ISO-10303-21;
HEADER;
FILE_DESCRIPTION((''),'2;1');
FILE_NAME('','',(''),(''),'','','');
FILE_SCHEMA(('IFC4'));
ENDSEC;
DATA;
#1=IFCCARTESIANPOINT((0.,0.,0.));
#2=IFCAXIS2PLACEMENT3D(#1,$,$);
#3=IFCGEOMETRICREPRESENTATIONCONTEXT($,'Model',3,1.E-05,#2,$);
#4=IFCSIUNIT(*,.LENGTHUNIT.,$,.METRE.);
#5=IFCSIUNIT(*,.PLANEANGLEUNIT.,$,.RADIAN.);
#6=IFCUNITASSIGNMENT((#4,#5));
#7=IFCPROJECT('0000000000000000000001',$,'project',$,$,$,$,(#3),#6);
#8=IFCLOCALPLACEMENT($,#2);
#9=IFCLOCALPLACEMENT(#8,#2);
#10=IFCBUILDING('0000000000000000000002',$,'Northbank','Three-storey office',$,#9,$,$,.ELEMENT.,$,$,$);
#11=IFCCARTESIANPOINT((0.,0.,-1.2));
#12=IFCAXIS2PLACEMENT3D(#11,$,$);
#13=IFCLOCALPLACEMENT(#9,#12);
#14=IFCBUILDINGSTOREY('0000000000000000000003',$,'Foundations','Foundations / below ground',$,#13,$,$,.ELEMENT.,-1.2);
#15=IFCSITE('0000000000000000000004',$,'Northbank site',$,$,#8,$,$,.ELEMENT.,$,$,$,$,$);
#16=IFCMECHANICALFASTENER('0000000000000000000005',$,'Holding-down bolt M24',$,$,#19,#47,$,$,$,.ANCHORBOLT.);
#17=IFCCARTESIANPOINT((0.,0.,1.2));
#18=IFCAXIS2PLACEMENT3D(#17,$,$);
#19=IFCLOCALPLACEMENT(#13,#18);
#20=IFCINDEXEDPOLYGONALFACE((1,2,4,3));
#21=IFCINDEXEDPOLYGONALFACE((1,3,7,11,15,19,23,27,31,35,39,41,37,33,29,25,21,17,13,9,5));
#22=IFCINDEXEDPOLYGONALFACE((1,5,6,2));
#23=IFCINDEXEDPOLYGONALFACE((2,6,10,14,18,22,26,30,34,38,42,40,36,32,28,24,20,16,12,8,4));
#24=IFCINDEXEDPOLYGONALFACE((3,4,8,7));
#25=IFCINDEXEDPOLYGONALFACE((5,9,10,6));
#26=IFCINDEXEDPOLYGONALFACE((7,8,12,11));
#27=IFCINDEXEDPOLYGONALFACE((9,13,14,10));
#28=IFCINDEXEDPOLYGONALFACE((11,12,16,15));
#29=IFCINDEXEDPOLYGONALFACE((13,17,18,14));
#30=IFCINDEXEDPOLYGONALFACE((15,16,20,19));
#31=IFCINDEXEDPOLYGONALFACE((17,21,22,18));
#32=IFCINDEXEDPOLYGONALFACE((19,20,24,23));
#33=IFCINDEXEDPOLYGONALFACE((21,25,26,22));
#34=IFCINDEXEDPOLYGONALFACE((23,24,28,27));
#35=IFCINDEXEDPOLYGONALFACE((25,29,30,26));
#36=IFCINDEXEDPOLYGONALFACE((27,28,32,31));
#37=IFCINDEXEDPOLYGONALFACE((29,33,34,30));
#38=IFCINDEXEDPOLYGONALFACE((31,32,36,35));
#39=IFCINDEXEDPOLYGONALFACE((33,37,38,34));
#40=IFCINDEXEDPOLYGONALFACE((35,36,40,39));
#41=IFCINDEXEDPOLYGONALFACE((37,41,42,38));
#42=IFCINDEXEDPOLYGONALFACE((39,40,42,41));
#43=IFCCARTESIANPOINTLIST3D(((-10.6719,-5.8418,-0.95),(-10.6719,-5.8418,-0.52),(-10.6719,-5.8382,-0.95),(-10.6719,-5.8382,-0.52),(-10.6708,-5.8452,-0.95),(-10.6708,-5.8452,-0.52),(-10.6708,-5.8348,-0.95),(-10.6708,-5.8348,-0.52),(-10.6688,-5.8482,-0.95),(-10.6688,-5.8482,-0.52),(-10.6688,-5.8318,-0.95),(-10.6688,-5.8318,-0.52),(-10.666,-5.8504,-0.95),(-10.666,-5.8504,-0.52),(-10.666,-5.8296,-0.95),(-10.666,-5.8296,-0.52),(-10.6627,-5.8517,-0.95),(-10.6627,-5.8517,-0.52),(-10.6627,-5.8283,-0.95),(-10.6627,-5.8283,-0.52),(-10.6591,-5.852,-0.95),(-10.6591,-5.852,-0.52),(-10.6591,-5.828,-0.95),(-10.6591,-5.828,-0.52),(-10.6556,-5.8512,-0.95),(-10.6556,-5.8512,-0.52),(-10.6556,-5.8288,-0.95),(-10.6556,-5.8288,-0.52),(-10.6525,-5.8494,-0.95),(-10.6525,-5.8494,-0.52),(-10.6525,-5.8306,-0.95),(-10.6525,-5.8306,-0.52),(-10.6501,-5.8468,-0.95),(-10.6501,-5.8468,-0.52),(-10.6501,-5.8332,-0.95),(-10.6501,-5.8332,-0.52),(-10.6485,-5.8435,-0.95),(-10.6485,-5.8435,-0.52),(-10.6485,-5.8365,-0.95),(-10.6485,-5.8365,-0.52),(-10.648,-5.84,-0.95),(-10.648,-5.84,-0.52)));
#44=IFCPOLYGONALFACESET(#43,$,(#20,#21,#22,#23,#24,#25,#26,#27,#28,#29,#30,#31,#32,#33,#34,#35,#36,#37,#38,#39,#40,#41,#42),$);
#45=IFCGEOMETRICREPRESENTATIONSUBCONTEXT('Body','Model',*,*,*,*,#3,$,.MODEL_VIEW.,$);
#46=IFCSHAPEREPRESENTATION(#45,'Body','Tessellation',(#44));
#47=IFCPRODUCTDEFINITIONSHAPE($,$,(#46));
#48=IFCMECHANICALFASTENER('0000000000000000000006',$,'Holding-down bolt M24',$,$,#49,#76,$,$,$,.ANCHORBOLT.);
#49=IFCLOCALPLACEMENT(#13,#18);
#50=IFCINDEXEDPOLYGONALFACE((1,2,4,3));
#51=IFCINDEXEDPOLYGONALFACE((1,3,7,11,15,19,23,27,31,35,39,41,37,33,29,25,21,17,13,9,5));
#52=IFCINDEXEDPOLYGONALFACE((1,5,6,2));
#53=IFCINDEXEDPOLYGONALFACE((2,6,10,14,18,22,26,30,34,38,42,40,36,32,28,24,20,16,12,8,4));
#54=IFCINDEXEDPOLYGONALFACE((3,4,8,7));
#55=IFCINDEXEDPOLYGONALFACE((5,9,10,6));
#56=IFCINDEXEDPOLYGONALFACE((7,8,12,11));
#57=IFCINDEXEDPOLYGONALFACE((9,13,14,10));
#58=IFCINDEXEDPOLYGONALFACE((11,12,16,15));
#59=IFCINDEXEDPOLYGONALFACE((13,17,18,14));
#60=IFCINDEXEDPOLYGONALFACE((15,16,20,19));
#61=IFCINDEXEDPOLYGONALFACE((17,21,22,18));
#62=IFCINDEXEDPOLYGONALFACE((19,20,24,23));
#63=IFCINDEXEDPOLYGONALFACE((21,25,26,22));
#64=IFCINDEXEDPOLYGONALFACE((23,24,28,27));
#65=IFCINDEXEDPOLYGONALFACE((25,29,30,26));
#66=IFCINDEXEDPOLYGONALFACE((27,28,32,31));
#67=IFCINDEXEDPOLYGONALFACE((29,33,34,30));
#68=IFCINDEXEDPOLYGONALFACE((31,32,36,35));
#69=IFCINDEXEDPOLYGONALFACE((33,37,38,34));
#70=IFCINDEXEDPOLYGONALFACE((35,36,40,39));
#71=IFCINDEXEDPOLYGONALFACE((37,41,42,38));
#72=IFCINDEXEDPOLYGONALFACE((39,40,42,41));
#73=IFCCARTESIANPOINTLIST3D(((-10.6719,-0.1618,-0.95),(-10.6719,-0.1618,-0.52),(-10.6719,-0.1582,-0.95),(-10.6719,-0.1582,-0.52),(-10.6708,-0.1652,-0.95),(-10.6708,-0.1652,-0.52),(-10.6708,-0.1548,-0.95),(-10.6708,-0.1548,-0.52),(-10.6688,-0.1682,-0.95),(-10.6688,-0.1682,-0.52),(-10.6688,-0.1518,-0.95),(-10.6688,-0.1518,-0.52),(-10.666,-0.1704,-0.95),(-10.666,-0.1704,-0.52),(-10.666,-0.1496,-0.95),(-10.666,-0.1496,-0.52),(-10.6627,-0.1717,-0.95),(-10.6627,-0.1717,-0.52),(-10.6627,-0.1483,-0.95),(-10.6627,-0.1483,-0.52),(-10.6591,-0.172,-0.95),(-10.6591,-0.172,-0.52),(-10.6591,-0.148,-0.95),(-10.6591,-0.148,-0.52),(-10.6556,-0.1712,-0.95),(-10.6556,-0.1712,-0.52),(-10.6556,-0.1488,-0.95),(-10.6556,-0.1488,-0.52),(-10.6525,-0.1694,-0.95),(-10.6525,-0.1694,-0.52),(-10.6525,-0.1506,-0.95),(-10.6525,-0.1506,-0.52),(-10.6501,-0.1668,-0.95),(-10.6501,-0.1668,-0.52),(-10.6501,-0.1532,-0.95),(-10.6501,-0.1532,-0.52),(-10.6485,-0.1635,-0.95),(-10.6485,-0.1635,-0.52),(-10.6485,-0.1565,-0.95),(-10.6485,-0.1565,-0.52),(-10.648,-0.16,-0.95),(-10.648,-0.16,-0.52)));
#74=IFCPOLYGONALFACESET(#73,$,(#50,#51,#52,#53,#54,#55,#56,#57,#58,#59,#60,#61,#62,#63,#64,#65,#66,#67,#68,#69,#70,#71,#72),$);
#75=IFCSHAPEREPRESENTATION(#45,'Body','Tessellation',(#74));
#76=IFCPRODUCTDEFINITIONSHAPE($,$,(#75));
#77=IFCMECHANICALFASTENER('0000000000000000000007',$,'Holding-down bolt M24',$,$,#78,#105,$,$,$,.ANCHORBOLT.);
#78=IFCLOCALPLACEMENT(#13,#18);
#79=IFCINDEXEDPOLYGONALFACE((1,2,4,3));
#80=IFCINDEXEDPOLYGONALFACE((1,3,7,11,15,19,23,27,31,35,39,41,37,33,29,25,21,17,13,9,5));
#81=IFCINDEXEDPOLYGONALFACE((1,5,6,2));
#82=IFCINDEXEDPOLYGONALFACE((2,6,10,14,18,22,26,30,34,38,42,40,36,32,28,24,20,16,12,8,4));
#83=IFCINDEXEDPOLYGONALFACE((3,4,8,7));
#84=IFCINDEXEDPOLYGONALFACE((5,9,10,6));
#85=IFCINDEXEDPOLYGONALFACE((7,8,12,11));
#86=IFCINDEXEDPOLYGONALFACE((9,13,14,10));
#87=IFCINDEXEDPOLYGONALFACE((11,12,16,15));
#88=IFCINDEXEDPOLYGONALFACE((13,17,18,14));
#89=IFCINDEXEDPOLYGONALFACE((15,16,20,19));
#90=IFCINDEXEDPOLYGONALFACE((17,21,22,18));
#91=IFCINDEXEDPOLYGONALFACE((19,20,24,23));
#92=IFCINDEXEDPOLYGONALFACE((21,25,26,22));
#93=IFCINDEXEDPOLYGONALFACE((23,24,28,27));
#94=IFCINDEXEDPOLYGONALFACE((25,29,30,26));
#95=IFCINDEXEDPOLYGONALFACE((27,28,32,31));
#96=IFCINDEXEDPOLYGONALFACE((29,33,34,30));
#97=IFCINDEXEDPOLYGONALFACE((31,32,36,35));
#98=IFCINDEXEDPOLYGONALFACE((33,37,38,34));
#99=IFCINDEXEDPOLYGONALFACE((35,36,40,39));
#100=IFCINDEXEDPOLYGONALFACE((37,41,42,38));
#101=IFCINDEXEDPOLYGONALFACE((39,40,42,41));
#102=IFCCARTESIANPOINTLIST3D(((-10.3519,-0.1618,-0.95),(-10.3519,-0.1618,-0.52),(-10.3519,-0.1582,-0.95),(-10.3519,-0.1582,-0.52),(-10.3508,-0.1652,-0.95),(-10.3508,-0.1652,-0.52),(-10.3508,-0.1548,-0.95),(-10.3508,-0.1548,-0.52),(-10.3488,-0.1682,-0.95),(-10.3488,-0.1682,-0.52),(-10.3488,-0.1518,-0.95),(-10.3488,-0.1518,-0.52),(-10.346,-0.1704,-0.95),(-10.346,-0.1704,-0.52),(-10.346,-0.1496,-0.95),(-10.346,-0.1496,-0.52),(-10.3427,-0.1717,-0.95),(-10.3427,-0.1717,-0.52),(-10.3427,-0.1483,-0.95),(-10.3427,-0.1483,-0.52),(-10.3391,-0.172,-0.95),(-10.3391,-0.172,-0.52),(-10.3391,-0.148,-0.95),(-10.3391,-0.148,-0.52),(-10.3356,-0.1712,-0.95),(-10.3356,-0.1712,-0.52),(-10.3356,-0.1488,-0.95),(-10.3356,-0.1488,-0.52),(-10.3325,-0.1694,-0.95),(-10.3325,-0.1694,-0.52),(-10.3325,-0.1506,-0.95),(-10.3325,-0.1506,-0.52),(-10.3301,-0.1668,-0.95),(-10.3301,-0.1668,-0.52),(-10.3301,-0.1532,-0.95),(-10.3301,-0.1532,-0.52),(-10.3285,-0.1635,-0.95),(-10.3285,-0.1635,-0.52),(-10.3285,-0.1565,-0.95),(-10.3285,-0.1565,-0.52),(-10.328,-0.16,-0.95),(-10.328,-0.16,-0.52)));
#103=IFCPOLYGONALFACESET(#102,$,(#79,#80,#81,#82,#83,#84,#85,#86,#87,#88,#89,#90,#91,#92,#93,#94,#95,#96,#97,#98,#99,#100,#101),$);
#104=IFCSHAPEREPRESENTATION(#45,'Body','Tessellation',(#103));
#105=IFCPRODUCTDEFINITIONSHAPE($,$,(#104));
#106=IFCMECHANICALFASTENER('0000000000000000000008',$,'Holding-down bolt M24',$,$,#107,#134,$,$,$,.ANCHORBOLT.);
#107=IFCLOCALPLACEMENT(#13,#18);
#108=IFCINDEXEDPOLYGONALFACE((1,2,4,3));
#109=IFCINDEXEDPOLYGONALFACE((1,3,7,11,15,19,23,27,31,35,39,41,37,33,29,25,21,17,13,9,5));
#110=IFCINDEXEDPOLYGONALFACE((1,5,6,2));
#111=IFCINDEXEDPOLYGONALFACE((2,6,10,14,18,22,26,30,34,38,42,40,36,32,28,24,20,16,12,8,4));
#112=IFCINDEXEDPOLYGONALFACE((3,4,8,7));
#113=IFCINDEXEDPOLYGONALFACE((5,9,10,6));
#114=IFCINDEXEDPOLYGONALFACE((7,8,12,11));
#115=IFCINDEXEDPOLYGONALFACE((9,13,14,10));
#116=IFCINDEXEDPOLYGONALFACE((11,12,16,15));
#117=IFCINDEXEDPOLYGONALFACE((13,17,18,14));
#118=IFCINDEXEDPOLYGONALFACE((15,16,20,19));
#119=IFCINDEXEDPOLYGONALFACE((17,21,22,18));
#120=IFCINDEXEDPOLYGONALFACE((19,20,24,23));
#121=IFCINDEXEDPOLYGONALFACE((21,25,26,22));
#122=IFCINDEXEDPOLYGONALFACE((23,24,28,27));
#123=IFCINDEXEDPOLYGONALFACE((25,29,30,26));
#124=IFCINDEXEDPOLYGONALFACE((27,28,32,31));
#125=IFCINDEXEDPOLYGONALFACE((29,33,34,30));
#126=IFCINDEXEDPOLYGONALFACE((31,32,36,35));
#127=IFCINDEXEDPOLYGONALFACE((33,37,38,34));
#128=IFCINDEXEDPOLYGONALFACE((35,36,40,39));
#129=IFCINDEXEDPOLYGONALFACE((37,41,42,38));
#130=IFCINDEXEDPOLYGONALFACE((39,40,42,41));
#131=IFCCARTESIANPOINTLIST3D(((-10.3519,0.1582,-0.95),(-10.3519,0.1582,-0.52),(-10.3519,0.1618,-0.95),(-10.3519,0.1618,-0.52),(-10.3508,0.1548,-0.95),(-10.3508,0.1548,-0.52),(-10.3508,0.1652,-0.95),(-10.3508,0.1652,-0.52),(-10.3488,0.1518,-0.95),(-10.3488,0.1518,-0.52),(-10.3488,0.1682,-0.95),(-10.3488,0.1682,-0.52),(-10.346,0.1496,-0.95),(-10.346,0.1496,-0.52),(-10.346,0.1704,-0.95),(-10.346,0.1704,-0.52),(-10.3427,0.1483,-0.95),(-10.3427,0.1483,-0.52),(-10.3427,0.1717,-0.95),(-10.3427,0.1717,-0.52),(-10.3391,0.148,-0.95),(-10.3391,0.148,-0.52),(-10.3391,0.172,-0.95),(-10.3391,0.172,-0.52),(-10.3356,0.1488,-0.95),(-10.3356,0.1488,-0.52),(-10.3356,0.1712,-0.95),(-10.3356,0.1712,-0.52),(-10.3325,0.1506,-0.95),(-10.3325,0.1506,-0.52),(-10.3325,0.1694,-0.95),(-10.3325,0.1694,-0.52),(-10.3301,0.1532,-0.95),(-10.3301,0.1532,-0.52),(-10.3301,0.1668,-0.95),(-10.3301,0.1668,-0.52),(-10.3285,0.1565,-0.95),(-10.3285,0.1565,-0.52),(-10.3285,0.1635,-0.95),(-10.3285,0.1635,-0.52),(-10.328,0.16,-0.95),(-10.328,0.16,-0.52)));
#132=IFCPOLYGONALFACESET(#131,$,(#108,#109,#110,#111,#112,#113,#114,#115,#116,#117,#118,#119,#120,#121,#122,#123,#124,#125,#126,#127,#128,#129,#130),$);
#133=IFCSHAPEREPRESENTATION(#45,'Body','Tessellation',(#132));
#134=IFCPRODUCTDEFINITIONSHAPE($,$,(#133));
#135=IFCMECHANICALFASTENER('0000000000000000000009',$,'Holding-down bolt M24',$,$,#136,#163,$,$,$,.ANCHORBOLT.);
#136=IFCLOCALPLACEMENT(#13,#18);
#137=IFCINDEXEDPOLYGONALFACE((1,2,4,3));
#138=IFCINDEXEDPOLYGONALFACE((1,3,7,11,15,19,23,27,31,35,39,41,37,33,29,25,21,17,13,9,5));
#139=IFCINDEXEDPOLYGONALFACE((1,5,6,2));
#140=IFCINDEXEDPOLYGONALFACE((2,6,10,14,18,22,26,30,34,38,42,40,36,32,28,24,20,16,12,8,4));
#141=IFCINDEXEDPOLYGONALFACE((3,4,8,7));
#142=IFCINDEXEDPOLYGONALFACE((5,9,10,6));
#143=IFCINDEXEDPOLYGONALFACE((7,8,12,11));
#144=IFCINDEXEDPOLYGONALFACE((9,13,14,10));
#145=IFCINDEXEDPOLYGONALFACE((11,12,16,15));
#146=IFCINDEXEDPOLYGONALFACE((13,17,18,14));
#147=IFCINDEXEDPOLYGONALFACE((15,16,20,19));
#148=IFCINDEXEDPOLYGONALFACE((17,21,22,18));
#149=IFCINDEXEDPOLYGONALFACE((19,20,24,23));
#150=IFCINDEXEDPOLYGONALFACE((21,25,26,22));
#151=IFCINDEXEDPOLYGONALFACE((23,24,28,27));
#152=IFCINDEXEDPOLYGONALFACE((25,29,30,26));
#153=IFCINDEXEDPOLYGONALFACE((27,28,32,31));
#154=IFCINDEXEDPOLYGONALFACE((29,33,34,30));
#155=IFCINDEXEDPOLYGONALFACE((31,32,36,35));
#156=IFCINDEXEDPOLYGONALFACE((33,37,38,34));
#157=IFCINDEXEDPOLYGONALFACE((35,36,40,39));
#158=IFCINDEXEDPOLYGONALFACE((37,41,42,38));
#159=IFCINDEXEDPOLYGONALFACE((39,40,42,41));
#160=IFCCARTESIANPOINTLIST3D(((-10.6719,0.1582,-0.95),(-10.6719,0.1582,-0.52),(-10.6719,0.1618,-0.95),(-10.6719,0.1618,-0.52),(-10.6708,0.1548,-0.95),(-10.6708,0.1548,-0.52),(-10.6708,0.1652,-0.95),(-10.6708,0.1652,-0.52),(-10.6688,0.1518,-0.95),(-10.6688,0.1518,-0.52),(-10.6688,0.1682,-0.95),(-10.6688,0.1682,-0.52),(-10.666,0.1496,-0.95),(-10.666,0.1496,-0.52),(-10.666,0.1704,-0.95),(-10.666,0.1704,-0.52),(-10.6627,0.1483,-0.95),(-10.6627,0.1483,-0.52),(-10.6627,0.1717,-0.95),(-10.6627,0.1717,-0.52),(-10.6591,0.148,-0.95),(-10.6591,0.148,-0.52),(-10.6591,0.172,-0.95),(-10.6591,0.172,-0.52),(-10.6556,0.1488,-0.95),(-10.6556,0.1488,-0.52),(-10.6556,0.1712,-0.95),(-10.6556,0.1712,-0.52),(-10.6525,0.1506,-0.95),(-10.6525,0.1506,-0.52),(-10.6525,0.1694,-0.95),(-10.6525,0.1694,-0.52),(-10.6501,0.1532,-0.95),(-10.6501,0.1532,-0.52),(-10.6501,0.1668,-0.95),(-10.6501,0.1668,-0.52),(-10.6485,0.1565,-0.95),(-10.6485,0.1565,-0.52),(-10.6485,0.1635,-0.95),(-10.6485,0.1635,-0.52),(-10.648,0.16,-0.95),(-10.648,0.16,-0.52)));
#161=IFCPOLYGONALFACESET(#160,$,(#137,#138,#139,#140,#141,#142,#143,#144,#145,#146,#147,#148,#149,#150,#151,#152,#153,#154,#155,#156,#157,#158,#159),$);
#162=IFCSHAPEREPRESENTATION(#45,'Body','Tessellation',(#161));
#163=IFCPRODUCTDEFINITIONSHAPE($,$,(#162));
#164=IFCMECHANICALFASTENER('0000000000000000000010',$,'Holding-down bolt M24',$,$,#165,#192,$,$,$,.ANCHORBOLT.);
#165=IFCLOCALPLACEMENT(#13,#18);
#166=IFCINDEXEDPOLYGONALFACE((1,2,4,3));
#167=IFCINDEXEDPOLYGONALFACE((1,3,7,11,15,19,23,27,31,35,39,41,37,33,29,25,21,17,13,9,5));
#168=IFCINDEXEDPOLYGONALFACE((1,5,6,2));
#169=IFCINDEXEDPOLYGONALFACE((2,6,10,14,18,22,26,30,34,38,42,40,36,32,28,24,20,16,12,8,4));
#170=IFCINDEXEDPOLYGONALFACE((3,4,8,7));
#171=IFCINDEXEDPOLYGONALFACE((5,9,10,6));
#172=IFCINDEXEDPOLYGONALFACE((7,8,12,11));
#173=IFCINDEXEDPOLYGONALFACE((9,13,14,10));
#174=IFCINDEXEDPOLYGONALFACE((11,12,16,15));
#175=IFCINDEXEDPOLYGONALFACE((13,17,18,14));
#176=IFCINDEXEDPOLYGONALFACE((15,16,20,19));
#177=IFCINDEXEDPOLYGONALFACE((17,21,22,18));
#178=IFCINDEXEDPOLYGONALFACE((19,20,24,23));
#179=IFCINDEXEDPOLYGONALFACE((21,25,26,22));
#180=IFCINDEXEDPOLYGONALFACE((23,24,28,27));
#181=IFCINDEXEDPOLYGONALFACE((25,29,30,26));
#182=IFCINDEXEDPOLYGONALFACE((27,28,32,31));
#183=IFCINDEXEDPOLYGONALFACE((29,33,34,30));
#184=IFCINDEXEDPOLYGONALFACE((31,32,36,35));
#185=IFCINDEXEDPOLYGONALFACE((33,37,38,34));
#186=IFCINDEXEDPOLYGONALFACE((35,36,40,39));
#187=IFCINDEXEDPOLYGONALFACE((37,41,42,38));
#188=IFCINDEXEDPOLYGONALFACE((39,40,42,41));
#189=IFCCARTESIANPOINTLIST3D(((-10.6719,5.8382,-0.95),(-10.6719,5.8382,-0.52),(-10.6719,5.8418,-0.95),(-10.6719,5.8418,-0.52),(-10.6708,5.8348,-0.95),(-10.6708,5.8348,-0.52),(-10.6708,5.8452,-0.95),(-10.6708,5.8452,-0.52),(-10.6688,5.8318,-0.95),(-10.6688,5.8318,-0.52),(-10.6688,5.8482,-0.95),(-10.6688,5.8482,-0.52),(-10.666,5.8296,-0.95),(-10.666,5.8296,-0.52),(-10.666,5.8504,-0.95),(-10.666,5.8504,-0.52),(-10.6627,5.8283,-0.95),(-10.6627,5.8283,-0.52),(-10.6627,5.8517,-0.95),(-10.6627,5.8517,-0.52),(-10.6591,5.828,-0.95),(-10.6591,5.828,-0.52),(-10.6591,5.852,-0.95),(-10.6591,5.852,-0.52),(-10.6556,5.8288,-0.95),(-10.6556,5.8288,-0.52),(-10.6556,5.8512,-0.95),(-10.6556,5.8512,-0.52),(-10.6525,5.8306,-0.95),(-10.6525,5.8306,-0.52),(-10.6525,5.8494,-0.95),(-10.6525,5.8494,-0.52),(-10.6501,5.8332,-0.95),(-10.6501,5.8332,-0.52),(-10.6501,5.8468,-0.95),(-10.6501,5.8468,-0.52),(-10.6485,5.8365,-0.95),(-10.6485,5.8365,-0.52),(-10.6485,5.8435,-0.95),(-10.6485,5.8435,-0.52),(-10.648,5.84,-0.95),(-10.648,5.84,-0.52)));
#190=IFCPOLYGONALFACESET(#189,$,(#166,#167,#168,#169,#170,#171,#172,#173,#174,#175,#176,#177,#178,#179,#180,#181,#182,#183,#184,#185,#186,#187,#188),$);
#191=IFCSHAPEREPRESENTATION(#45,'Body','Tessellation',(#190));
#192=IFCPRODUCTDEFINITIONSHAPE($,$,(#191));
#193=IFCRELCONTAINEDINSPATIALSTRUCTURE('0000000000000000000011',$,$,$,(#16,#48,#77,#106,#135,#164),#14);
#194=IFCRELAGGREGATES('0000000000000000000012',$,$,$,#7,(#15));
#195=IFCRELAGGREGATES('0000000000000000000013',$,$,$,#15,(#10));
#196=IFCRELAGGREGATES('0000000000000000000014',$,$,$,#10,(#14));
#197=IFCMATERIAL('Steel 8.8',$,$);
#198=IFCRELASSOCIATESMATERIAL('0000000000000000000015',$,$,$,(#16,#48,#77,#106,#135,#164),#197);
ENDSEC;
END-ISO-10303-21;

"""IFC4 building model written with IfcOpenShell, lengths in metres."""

from ifc_helpers import new_model, si_unit, frame, origin, place, context, subcontext, project, spatial, circle, extrude, material, element, save


model = new_model("IFC4")

# Units and contexts
model_context = context("Model", 3, precision=1e-05, world=origin())
body_context = subcontext(model_context, "Body", "Model", "MODEL_VIEW")
ifc_project = project(units=[si_unit("LENGTHUNIT", "METRE"), si_unit("PLANEANGLEUNIT", "RADIAN")], contexts=[model_context])

# Site, building, storey
site_placement = place(None, origin())
site = spatial("IfcSite", under=ifc_project, at=site_placement, Name="Northbank site", CompositionType="ELEMENT")
building_placement = place(site_placement, origin())
building = spatial("IfcBuilding", under=site, at=building_placement, Name="Northbank", Description="Three-storey office", CompositionType="ELEMENT")
storey_placement = place(building_placement, frame((0.0, 0.0, -1.2)))
storey = spatial("IfcBuildingStorey", under=building, at=storey_placement, Name="Foundations", Description="Foundations / below ground", CompositionType="ELEMENT", Elevation=-1.2)

# Mechanical fasteners
ifc_material_1 = material(Name="Steel 8.8")
mechanical_fastener_1_placement = place(storey_placement, frame((0.0, 0.0, 1.2)))
element("IfcMechanicalFastener", 1, at=mechanical_fastener_1_placement, inside=storey, material=ifc_material_1, Name="Holding-down bolt M24", PredefinedType="ANCHORBOLT", context=body_context, shape_type="SweptSolid", body=[
    extrude(circle(Radius=0.012), frame((-10.66, -5.84, -0.95), z_axis=(0.0, 0.0, 1.0), x_axis=(1.0, 0.0, 0.0)), (0.0, 0.0, 1.0), 0.43),
])
mechanical_fastener_2_placement = place(storey_placement, frame((0.0, 0.0, 1.2)))
element("IfcMechanicalFastener", 2, at=mechanical_fastener_2_placement, inside=storey, material=ifc_material_1, Name="Holding-down bolt M24", PredefinedType="ANCHORBOLT", context=body_context, shape_type="SweptSolid", body=[
    extrude(circle(Radius=0.012), frame((-10.66, -0.16, -0.95), z_axis=(0.0, 0.0, 1.0), x_axis=(1.0, 0.0, 0.0)), (0.0, 0.0, 1.0), 0.43),
])
mechanical_fastener_3_placement = place(storey_placement, frame((0.0, 0.0, 1.2)))
element("IfcMechanicalFastener", 3, at=mechanical_fastener_3_placement, inside=storey, material=ifc_material_1, Name="Holding-down bolt M24", PredefinedType="ANCHORBOLT", context=body_context, shape_type="SweptSolid", body=[
    extrude(circle(Radius=0.012), frame((-10.34, -0.16, -0.95), z_axis=(0.0, 0.0, 1.0), x_axis=(1.0, 0.0, 0.0)), (0.0, 0.0, 1.0), 0.43),
])
mechanical_fastener_4_placement = place(storey_placement, frame((0.0, 0.0, 1.2)))
element("IfcMechanicalFastener", 4, at=mechanical_fastener_4_placement, inside=storey, material=ifc_material_1, Name="Holding-down bolt M24", PredefinedType="ANCHORBOLT", context=body_context, shape_type="SweptSolid", body=[
    extrude(circle(Radius=0.012), frame((-10.34, 0.16, -0.95), z_axis=(0.0, 0.0, 1.0), x_axis=(1.0, 0.0, 0.0)), (0.0, 0.0, 1.0), 0.43),
])
mechanical_fastener_5_placement = place(storey_placement, frame((0.0, 0.0, 1.2)))
element("IfcMechanicalFastener", 5, at=mechanical_fastener_5_placement, inside=storey, material=ifc_material_1, Name="Holding-down bolt M24", PredefinedType="ANCHORBOLT", context=body_context, shape_type="SweptSolid", body=[
    extrude(circle(Radius=0.012), frame((-10.66, 0.16, -0.95), z_axis=(0.0, 0.0, 1.0), x_axis=(1.0, 0.0, 0.0)), (0.0, 0.0, 1.0), 0.43),
])
mechanical_fastener_6_placement = place(storey_placement, frame((0.0, 0.0, 1.2)))
element("IfcMechanicalFastener", 6, at=mechanical_fastener_6_placement, inside=storey, material=ifc_material_1, Name="Holding-down bolt M24", PredefinedType="ANCHORBOLT", context=body_context, shape_type="SweptSolid", body=[
    extrude(circle(Radius=0.012), frame((-10.66, 5.84, -0.95), z_axis=(0.0, 0.0, 1.0), x_axis=(1.0, 0.0, 0.0)), (0.0, 0.0, 1.0), 0.43),
])

save(model, "model.ifc")
